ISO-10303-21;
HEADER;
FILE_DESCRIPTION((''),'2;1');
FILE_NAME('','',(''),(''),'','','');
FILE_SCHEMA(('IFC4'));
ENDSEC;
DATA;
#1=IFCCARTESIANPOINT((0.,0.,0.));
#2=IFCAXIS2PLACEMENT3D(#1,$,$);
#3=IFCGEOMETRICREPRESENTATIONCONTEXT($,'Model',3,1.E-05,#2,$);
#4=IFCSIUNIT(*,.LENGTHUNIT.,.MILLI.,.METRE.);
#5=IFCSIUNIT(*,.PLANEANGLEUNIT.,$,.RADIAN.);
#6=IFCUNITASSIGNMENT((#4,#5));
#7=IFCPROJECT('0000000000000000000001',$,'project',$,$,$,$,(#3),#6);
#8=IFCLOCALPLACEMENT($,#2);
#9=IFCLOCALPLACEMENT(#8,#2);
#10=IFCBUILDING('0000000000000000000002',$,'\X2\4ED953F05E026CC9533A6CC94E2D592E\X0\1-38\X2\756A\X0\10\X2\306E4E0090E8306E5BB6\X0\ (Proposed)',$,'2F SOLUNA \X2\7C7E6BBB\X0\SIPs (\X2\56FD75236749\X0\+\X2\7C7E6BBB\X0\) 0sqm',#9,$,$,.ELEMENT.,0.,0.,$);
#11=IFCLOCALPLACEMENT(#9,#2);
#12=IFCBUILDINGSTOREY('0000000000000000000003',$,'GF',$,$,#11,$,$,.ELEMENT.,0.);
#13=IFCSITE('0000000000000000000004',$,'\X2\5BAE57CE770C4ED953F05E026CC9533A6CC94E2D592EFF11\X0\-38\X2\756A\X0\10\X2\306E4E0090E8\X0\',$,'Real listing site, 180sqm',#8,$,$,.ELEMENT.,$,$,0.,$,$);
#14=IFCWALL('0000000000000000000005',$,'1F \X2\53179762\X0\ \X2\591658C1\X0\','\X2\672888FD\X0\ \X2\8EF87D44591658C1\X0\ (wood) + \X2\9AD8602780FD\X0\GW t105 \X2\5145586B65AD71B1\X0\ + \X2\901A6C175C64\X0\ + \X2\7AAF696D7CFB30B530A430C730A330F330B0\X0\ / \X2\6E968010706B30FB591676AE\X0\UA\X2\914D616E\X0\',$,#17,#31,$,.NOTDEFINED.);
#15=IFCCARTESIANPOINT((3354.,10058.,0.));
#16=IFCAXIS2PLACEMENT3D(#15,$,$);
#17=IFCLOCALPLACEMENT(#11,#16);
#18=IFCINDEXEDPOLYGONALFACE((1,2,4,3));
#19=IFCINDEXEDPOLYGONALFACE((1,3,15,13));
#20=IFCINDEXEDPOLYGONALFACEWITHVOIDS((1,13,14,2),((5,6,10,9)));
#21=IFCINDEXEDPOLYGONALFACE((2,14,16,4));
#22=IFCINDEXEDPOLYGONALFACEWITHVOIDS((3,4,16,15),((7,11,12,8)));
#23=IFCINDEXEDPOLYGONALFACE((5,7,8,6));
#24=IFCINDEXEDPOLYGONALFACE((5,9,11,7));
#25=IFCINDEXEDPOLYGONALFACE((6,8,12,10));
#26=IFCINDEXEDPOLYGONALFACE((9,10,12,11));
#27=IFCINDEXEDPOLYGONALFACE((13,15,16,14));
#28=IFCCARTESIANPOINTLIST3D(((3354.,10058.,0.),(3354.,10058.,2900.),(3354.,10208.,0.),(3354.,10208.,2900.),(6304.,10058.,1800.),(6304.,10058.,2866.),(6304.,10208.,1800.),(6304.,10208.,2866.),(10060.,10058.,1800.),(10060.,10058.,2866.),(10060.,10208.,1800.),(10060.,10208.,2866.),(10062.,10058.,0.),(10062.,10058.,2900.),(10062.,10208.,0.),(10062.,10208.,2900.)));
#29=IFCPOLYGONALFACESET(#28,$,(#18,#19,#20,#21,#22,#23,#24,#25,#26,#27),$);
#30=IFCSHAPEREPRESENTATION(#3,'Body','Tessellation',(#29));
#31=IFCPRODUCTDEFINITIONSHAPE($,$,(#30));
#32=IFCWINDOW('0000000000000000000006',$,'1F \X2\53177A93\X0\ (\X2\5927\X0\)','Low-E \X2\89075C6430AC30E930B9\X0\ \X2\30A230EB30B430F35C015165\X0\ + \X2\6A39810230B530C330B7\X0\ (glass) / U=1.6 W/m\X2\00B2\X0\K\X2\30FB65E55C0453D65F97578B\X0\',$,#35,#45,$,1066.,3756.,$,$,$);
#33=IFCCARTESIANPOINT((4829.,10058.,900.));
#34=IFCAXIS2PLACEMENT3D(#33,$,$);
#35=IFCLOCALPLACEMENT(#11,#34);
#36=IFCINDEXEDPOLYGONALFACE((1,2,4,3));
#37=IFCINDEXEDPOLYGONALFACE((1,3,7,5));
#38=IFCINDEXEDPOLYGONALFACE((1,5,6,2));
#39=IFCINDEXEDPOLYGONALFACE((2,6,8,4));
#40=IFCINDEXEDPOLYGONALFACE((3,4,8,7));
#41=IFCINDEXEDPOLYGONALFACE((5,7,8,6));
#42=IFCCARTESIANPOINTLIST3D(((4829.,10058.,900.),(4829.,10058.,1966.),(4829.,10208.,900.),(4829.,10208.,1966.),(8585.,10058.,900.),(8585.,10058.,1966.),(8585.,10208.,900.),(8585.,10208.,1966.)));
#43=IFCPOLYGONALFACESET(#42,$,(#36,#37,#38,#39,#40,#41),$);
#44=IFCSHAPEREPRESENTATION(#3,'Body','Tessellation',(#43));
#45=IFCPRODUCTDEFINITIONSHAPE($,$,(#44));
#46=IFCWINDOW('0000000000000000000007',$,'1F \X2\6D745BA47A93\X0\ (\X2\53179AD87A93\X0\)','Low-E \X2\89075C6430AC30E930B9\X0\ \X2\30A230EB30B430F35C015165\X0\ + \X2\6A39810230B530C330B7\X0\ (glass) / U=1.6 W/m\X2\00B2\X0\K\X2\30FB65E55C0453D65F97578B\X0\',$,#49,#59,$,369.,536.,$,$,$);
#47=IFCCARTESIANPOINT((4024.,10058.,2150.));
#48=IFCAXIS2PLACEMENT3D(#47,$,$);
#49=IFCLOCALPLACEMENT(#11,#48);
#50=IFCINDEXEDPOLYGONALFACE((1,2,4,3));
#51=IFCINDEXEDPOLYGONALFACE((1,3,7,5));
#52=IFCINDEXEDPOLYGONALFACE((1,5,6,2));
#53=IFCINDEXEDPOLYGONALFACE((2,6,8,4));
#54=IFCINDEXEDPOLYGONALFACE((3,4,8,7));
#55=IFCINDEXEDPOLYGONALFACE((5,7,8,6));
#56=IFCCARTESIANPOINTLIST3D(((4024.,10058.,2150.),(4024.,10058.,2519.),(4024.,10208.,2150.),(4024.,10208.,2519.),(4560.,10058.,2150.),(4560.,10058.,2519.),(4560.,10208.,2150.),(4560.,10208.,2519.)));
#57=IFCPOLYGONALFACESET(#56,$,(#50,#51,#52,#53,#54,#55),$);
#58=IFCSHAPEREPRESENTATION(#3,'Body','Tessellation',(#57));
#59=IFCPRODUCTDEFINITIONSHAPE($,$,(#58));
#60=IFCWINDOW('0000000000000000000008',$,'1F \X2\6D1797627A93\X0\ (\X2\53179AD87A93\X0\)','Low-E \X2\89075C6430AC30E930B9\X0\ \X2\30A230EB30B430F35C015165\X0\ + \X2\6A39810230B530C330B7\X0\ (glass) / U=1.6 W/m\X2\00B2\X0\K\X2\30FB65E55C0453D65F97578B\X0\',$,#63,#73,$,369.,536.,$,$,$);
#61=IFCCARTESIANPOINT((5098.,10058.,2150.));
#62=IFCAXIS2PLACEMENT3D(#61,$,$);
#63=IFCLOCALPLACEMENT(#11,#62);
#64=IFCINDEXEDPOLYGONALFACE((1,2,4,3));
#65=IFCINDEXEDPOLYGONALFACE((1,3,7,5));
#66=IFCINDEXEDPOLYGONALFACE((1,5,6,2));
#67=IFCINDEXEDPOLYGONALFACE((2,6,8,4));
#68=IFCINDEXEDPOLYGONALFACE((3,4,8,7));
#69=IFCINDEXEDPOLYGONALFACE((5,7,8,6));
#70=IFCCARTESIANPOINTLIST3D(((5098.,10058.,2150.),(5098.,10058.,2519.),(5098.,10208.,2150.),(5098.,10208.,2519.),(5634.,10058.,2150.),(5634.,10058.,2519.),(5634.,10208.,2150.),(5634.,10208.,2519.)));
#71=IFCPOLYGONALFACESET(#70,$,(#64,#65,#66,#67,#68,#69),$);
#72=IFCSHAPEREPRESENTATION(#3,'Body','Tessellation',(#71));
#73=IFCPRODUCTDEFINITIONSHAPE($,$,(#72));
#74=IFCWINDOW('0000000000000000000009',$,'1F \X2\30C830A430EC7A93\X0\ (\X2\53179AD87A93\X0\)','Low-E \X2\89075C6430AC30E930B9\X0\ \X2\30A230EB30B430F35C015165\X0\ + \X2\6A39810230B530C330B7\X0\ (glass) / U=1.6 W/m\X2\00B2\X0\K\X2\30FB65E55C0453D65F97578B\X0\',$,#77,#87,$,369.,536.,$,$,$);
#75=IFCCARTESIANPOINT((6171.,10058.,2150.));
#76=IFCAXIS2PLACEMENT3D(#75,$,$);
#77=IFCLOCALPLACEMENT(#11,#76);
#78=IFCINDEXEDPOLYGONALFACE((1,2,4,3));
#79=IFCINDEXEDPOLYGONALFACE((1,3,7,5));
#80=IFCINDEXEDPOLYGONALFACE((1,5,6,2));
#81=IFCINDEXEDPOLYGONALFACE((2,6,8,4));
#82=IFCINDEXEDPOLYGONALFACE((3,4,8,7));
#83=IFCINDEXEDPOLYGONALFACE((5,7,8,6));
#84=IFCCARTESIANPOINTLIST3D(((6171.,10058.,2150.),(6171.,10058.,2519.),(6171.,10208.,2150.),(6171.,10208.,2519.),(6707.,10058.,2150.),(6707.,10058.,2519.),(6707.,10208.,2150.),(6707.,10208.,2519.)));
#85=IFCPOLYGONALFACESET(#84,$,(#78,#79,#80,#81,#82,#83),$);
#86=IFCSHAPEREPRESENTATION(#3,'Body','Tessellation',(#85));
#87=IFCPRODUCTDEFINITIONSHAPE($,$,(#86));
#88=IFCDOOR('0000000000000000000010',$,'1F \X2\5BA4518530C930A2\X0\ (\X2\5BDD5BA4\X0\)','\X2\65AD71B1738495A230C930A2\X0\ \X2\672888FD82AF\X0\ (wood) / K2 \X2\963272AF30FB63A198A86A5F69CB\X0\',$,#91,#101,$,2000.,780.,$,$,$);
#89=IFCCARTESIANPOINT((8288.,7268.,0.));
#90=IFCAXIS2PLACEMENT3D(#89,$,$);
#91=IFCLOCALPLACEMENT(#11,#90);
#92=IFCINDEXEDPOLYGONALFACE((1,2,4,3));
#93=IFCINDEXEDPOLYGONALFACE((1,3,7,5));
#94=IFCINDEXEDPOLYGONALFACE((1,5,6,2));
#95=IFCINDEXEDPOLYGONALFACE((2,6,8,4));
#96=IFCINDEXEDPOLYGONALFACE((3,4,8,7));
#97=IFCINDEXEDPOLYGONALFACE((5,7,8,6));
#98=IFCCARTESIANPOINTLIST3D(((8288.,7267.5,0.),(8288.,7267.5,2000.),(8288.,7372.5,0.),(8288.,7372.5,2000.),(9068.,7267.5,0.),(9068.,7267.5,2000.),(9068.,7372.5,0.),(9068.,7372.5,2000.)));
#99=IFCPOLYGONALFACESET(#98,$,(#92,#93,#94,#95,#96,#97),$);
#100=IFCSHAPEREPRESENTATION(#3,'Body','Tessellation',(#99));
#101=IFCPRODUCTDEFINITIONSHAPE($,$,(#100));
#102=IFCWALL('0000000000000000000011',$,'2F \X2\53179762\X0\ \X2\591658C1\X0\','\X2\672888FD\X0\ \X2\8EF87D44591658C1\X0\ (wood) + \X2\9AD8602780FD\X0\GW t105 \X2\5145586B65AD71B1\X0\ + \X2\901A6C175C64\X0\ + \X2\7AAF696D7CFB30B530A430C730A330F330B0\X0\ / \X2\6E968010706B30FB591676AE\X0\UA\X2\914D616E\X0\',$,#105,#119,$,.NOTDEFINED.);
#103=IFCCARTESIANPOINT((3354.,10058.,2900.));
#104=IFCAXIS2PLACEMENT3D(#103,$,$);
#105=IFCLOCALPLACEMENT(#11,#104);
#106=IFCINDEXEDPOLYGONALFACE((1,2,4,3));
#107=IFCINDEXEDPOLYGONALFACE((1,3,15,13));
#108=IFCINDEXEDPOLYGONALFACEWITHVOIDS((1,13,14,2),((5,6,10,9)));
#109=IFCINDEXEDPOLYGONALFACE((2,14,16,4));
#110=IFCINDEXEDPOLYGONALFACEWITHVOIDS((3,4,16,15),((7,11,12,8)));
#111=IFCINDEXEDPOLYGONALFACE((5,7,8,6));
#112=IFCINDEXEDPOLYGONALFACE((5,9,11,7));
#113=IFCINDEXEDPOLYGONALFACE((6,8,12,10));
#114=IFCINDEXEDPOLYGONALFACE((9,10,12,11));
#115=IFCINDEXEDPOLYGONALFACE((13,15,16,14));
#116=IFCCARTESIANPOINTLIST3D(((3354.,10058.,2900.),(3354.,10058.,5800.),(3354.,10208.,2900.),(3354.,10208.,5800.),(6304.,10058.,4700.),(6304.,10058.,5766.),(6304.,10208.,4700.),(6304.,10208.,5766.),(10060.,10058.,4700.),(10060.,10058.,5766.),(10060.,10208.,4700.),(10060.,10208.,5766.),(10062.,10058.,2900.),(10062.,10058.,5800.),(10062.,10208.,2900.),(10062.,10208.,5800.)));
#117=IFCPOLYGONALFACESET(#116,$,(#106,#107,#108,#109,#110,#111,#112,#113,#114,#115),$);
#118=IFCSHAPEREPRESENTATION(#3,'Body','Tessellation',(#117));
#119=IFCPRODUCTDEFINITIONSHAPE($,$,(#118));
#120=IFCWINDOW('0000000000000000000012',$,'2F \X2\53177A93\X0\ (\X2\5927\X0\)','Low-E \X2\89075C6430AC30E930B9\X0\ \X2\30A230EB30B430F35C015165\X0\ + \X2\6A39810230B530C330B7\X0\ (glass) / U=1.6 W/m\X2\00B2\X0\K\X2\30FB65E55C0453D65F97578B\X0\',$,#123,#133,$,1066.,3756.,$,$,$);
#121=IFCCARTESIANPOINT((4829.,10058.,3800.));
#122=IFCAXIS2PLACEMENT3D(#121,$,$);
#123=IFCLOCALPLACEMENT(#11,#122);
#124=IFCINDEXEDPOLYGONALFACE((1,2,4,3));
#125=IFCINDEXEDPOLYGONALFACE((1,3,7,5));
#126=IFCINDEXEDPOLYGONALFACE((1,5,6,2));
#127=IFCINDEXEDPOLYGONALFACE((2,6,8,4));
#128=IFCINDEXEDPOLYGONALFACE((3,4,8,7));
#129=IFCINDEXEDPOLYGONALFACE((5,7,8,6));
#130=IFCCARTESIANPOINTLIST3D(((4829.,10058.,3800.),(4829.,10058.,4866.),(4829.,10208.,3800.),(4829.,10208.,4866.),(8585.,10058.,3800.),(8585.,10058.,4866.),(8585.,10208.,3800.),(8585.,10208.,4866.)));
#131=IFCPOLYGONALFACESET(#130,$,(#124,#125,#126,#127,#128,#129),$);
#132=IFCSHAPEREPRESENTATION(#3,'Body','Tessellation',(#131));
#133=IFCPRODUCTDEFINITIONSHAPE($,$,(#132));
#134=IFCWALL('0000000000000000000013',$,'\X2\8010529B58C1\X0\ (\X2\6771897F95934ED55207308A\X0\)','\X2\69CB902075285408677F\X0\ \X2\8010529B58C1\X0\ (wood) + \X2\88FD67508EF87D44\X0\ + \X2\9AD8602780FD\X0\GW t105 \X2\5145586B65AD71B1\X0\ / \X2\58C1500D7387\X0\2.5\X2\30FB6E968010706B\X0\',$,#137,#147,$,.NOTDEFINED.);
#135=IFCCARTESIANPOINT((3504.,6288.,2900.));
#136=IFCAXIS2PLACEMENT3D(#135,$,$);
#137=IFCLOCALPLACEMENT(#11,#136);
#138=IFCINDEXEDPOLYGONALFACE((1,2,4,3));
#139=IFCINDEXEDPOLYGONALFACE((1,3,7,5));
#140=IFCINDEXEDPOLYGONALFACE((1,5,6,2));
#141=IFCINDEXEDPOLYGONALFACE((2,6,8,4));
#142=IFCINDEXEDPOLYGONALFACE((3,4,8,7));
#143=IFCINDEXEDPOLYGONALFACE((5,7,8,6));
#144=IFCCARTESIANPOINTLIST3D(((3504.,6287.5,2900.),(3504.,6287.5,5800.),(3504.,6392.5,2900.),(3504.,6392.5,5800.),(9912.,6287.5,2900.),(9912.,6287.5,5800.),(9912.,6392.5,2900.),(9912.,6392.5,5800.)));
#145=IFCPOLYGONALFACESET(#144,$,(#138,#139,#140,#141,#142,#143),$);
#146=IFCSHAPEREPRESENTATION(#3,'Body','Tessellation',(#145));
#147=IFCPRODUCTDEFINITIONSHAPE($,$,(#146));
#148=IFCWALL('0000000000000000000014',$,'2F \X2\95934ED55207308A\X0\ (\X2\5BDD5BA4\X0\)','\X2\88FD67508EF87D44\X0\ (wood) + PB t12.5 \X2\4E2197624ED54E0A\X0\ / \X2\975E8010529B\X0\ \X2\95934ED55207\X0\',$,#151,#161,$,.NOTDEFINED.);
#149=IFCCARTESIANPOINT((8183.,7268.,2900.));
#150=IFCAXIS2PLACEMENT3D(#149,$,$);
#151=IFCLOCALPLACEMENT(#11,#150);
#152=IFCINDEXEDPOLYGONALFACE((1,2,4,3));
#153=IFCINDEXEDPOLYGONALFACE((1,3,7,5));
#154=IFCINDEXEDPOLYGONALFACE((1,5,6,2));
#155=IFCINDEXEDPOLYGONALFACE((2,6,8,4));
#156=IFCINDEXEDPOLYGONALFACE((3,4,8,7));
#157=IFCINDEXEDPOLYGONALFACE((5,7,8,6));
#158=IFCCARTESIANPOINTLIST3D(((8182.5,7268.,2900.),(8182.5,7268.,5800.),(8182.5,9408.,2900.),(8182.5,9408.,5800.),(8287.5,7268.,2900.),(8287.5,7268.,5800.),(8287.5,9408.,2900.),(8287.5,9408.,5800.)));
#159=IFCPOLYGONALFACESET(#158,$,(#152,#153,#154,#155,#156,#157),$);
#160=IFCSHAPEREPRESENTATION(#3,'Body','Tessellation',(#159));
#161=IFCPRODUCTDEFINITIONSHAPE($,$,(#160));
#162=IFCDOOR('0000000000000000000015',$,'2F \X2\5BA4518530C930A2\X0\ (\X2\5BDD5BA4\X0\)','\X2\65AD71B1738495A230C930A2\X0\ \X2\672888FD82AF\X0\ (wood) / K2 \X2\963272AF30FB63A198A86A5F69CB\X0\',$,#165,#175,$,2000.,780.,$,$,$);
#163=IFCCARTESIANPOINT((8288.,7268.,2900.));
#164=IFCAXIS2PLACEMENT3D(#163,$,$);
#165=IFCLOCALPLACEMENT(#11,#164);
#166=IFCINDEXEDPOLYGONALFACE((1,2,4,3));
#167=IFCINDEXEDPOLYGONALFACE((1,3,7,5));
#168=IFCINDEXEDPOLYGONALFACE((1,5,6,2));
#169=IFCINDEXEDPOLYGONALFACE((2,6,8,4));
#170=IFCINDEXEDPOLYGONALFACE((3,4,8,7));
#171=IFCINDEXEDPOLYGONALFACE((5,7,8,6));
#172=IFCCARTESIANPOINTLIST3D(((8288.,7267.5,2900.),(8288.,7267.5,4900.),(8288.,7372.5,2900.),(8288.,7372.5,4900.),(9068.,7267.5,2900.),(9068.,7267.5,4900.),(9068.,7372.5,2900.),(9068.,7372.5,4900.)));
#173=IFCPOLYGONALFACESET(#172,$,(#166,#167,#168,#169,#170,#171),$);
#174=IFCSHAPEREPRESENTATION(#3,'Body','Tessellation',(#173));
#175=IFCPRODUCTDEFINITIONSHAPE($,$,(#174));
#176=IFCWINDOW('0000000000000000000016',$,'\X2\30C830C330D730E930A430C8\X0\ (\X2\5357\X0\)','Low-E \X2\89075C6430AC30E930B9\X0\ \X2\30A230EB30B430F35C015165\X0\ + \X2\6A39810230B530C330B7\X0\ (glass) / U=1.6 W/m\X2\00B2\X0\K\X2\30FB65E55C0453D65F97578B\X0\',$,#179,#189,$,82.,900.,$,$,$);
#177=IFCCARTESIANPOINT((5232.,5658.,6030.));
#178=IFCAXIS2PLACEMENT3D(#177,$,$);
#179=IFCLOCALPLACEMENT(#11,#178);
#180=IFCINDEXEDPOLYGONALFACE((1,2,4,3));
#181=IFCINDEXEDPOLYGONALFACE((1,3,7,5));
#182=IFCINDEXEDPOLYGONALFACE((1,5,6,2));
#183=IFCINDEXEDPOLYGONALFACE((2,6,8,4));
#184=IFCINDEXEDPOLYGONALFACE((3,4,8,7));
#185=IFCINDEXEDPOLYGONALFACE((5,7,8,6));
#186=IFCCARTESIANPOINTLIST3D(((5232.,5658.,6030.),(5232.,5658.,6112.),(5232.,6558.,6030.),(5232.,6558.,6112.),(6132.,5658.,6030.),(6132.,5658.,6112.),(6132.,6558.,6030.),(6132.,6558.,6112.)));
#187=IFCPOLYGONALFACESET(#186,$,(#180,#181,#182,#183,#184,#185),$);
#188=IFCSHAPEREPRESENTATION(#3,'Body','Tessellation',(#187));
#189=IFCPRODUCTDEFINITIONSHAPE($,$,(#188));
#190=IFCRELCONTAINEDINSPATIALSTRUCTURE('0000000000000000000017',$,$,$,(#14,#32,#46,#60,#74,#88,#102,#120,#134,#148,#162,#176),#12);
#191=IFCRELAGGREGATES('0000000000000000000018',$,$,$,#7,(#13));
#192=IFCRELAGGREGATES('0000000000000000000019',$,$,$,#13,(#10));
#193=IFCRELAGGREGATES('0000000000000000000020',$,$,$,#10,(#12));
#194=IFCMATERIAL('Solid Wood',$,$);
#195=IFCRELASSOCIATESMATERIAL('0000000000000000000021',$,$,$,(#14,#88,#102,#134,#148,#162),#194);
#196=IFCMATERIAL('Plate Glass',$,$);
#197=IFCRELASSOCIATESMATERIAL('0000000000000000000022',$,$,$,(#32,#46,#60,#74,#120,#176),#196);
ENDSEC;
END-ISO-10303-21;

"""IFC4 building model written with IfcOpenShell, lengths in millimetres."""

from ifc_helpers import new_model, si_unit, frame, frame_2d, origin, place, context, project, spatial, rectangle, extrude, material, element, fill, save


model = new_model("IFC4")

# Units and contexts
model_context = context("Model", 3, precision=1e-05, world=origin())
ifc_project = project(units=[si_unit("LENGTHUNIT", "METRE", prefix="MILLI"), si_unit("PLANEANGLEUNIT", "RADIAN")], contexts=[model_context])

# Site, building, storey
site_placement = place(None, origin())
site = spatial("IfcSite", under=ifc_project, at=site_placement, Name="宮城県仙台市泉区泉中央１-38番10の一部", ObjectType="Real listing site, 180sqm", CompositionType="ELEMENT", RefElevation=0.0)
building_placement = place(site_placement, origin())
building = spatial("IfcBuilding", under=site, at=building_placement, Name="仙台市泉区泉中央1-38番10の一部の家 (Proposed)", ObjectType="2F SOLUNA 籾殻SIPs (国産杉+籾殻) 0sqm", CompositionType="ELEMENT", ElevationOfRefHeight=0.0, ElevationOfTerrain=0.0)
storey_placement = place(building_placement, origin())
storey = spatial("IfcBuildingStorey", under=building, at=storey_placement, Name="GF", CompositionType="ELEMENT", Elevation=0.0)

# Wall, openings, windows
ifc_material_1 = material(Name="Solid Wood")
wall_1_placement = place(storey_placement, frame((3354.0, 10058.0, 0.0)))
wall_1 = element("IfcWall", 1, at=wall_1_placement, inside=storey, material=ifc_material_1, Name="1F 北面 外壁", Description="木製 軸組外壁 (wood) + 高性能GW t105 充填断熱 + 通気層 + 窯業系サイディング / 準耐火・外皮UA配慮", PredefinedType="NOTDEFINED", context=model_context, shape_type="SweptSolid", body=[
    extrude(rectangle(XDim=6708.0, YDim=150.0, at=frame_2d((3354.0, 75.0))), frame((3354.0, 10058.0, 0.0)), (0.0, 0.0, 1.0), 2900.0),
])
opening_1_placement = place(storey_placement, frame((4829.0, 10058.0, 900.0)))
opening_1 = element("IfcOpeningElement", 2, at=opening_1_placement, cuts=wall_1, PredefinedType="NOTDEFINED", context=model_context, shape_type="SweptSolid", body=[
    extrude(rectangle(XDim=3756.0, YDim=150.0, at=frame_2d((1878.0, 75.0))), frame((4829.0, 10058.0, 900.0)), (0.0, 0.0, 1.0), 1066.0),
])
opening_2_placement = place(storey_placement, frame((4024.0, 10058.0, 2150.0)))
opening_2 = element("IfcOpeningElement", 3, at=opening_2_placement, cuts=wall_1, PredefinedType="NOTDEFINED", context=model_context, shape_type="SweptSolid", body=[
    extrude(rectangle(XDim=536.0, YDim=150.0, at=frame_2d((268.0, 75.0))), frame((4024.0, 10058.0, 2150.0)), (0.0, 0.0, 1.0), 369.0),
])
opening_3_placement = place(storey_placement, frame((5098.0, 10058.0, 2150.0)))
opening_3 = element("IfcOpeningElement", 4, at=opening_3_placement, cuts=wall_1, PredefinedType="NOTDEFINED", context=model_context, shape_type="SweptSolid", body=[
    extrude(rectangle(XDim=536.0, YDim=150.0, at=frame_2d((268.0, 75.0))), frame((5098.0, 10058.0, 2150.0)), (0.0, 0.0, 1.0), 369.0),
])
opening_4_placement = place(storey_placement, frame((6171.0, 10058.0, 2150.0)))
opening_4 = element("IfcOpeningElement", 5, at=opening_4_placement, cuts=wall_1, PredefinedType="NOTDEFINED", context=model_context, shape_type="SweptSolid", body=[
    extrude(rectangle(XDim=536.0, YDim=150.0, at=frame_2d((268.0, 75.0))), frame((6171.0, 10058.0, 2150.0)), (0.0, 0.0, 1.0), 369.0),
])
ifc_material_2 = material(Name="Plate Glass")
window_1_placement = place(storey_placement, frame((4829.0, 10058.0, 900.0)))
window_1 = element("IfcWindow", 6, at=window_1_placement, inside=storey, material=ifc_material_2, Name="1F 北窓 (大)", Description="Low-E 複層ガラス アルゴン封入 + 樹脂サッシ (glass) / U=1.6 W/m²K・日射取得型", OverallHeight=1066.0, OverallWidth=3756.0, context=model_context, shape_type="SweptSolid", body=[
    extrude(rectangle(XDim=3756.0, YDim=150.0, at=frame_2d((1878.0, 75.0))), frame((4829.0, 10058.0, 900.0)), (0.0, 0.0, 1.0), 1066.0),
])
fill(opening_1, window_1)
window_2_placement = place(storey_placement, frame((4024.0, 10058.0, 2150.0)))
window_2 = element("IfcWindow", 7, at=window_2_placement, inside=storey, material=ifc_material_2, Name="1F 浴室窓 (北高窓)", Description="Low-E 複層ガラス アルゴン封入 + 樹脂サッシ (glass) / U=1.6 W/m²K・日射取得型", OverallHeight=369.0, OverallWidth=536.0, context=model_context, shape_type="SweptSolid", body=[
    extrude(rectangle(XDim=536.0, YDim=150.0, at=frame_2d((268.0, 75.0))), frame((4024.0, 10058.0, 2150.0)), (0.0, 0.0, 1.0), 369.0),
])
fill(opening_2, window_2)
window_3_placement = place(storey_placement, frame((5098.0, 10058.0, 2150.0)))
window_3 = element("IfcWindow", 8, at=window_3_placement, inside=storey, material=ifc_material_2, Name="1F 洗面窓 (北高窓)", Description="Low-E 複層ガラス アルゴン封入 + 樹脂サッシ (glass) / U=1.6 W/m²K・日射取得型", OverallHeight=369.0, OverallWidth=536.0, context=model_context, shape_type="SweptSolid", body=[
    extrude(rectangle(XDim=536.0, YDim=150.0, at=frame_2d((268.0, 75.0))), frame((5098.0, 10058.0, 2150.0)), (0.0, 0.0, 1.0), 369.0),
])
fill(opening_3, window_3)
window_4_placement = place(storey_placement, frame((6171.0, 10058.0, 2150.0)))
window_4 = element("IfcWindow", 9, at=window_4_placement, inside=storey, material=ifc_material_2, Name="1F トイレ窓 (北高窓)", Description="Low-E 複層ガラス アルゴン封入 + 樹脂サッシ (glass) / U=1.6 W/m²K・日射取得型", OverallHeight=369.0, OverallWidth=536.0, context=model_context, shape_type="SweptSolid", body=[
    extrude(rectangle(XDim=536.0, YDim=150.0, at=frame_2d((268.0, 75.0))), frame((6171.0, 10058.0, 2150.0)), (0.0, 0.0, 1.0), 369.0),
])
fill(opening_4, window_4)

# Door
door_1_placement = place(storey_placement, frame((8288.0, 7268.0, 0.0)))
element("IfcDoor", 10, at=door_1_placement, inside=storey, material=ifc_material_1, Name="1F 室内ドア (寝室)", Description="断熱玄関ドア 木製芯 (wood) / K2 防犯・採風機構", OverallHeight=2000.0, OverallWidth=780.0, context=model_context, shape_type="SweptSolid", body=[
    extrude(rectangle(XDim=780.0, YDim=105.0, at=frame_2d((390.0, 52.0))), frame((8288.0, 7268.0, 0.0)), (0.0, 0.0, 1.0), 2000.0),
])

# Wall, opening, window
wall_2_placement = place(storey_placement, frame((3354.0, 10058.0, 2900.0)))
wall_2 = element("IfcWall", 11, at=wall_2_placement, inside=storey, material=ifc_material_1, Name="2F 北面 外壁", Description="木製 軸組外壁 (wood) + 高性能GW t105 充填断熱 + 通気層 + 窯業系サイディング / 準耐火・外皮UA配慮", PredefinedType="NOTDEFINED", context=model_context, shape_type="SweptSolid", body=[
    extrude(rectangle(XDim=6708.0, YDim=150.0, at=frame_2d((3354.0, 75.0))), frame((3354.0, 10058.0, 2900.0)), (0.0, 0.0, 1.0), 2900.0),
])
opening_5_placement = place(storey_placement, frame((4829.0, 10058.0, 3800.0)))
opening_5 = element("IfcOpeningElement", 12, at=opening_5_placement, cuts=wall_2, PredefinedType="NOTDEFINED", context=model_context, shape_type="SweptSolid", body=[
    extrude(rectangle(XDim=3756.0, YDim=150.0, at=frame_2d((1878.0, 75.0))), frame((4829.0, 10058.0, 3800.0)), (0.0, 0.0, 1.0), 1066.0),
])
window_5_placement = place(storey_placement, frame((4829.0, 10058.0, 3800.0)))
window_5 = element("IfcWindow", 13, at=window_5_placement, inside=storey, material=ifc_material_2, Name="2F 北窓 (大)", Description="Low-E 複層ガラス アルゴン封入 + 樹脂サッシ (glass) / U=1.6 W/m²K・日射取得型", OverallHeight=1066.0, OverallWidth=3756.0, context=model_context, shape_type="SweptSolid", body=[
    extrude(rectangle(XDim=3756.0, YDim=150.0, at=frame_2d((1878.0, 75.0))), frame((4829.0, 10058.0, 3800.0)), (0.0, 0.0, 1.0), 1066.0),
])
fill(opening_5, window_5)

# Walls
wall_3_placement = place(storey_placement, frame((3504.0, 6288.0, 2900.0)))
element("IfcWall", 14, at=wall_3_placement, inside=storey, material=ifc_material_1, Name="耐力壁 (東西間仕切り)", Description="構造用合板 耐力壁 (wood) + 製材軸組 + 高性能GW t105 充填断熱 / 壁倍率2.5・準耐火", PredefinedType="NOTDEFINED", context=model_context, shape_type="SweptSolid", body=[
    extrude(rectangle(XDim=6408.0, YDim=105.0, at=frame_2d((3204.0, 52.0))), frame((3504.0, 6288.0, 2900.0)), (0.0, 0.0, 1.0), 2900.0),
])
wall_4_placement = place(storey_placement, frame((8183.0, 7268.0, 2900.0)))
element("IfcWall", 15, at=wall_4_placement, inside=storey, material=ifc_material_1, Name="2F 間仕切り (寝室)", Description="製材軸組 (wood) + PB t12.5 両面仕上 / 非耐力 間仕切", PredefinedType="NOTDEFINED", context=model_context, shape_type="SweptSolid", body=[
    extrude(rectangle(XDim=105.0, YDim=2140.0, at=frame_2d((52.0, 1070.0))), frame((8183.0, 7268.0, 2900.0)), (0.0, 0.0, 1.0), 2900.0),
])

# Door
door_2_placement = place(storey_placement, frame((8288.0, 7268.0, 2900.0)))
element("IfcDoor", 16, at=door_2_placement, inside=storey, material=ifc_material_1, Name="2F 室内ドア (寝室)", Description="断熱玄関ドア 木製芯 (wood) / K2 防犯・採風機構", OverallHeight=2000.0, OverallWidth=780.0, context=model_context, shape_type="SweptSolid", body=[
    extrude(rectangle(XDim=780.0, YDim=105.0, at=frame_2d((390.0, 52.0))), frame((8288.0, 7268.0, 2900.0)), (0.0, 0.0, 1.0), 2000.0),
])

# Window
window_6_placement = place(storey_placement, frame((5232.0, 5658.0, 6030.0)))
element("IfcWindow", 17, at=window_6_placement, inside=storey, material=ifc_material_2, Name="トップライト (南)", Description="Low-E 複層ガラス アルゴン封入 + 樹脂サッシ (glass) / U=1.6 W/m²K・日射取得型", OverallHeight=82.0, OverallWidth=900.0, context=model_context, shape_type="SweptSolid", body=[
    extrude(rectangle(XDim=900.0, YDim=900.0, at=frame_2d((450.0, 450.0))), frame((5232.0, 5658.0, 6030.0)), (0.0, 0.0, 1.0), 82.0),
])

save(model, "model.ifc")
